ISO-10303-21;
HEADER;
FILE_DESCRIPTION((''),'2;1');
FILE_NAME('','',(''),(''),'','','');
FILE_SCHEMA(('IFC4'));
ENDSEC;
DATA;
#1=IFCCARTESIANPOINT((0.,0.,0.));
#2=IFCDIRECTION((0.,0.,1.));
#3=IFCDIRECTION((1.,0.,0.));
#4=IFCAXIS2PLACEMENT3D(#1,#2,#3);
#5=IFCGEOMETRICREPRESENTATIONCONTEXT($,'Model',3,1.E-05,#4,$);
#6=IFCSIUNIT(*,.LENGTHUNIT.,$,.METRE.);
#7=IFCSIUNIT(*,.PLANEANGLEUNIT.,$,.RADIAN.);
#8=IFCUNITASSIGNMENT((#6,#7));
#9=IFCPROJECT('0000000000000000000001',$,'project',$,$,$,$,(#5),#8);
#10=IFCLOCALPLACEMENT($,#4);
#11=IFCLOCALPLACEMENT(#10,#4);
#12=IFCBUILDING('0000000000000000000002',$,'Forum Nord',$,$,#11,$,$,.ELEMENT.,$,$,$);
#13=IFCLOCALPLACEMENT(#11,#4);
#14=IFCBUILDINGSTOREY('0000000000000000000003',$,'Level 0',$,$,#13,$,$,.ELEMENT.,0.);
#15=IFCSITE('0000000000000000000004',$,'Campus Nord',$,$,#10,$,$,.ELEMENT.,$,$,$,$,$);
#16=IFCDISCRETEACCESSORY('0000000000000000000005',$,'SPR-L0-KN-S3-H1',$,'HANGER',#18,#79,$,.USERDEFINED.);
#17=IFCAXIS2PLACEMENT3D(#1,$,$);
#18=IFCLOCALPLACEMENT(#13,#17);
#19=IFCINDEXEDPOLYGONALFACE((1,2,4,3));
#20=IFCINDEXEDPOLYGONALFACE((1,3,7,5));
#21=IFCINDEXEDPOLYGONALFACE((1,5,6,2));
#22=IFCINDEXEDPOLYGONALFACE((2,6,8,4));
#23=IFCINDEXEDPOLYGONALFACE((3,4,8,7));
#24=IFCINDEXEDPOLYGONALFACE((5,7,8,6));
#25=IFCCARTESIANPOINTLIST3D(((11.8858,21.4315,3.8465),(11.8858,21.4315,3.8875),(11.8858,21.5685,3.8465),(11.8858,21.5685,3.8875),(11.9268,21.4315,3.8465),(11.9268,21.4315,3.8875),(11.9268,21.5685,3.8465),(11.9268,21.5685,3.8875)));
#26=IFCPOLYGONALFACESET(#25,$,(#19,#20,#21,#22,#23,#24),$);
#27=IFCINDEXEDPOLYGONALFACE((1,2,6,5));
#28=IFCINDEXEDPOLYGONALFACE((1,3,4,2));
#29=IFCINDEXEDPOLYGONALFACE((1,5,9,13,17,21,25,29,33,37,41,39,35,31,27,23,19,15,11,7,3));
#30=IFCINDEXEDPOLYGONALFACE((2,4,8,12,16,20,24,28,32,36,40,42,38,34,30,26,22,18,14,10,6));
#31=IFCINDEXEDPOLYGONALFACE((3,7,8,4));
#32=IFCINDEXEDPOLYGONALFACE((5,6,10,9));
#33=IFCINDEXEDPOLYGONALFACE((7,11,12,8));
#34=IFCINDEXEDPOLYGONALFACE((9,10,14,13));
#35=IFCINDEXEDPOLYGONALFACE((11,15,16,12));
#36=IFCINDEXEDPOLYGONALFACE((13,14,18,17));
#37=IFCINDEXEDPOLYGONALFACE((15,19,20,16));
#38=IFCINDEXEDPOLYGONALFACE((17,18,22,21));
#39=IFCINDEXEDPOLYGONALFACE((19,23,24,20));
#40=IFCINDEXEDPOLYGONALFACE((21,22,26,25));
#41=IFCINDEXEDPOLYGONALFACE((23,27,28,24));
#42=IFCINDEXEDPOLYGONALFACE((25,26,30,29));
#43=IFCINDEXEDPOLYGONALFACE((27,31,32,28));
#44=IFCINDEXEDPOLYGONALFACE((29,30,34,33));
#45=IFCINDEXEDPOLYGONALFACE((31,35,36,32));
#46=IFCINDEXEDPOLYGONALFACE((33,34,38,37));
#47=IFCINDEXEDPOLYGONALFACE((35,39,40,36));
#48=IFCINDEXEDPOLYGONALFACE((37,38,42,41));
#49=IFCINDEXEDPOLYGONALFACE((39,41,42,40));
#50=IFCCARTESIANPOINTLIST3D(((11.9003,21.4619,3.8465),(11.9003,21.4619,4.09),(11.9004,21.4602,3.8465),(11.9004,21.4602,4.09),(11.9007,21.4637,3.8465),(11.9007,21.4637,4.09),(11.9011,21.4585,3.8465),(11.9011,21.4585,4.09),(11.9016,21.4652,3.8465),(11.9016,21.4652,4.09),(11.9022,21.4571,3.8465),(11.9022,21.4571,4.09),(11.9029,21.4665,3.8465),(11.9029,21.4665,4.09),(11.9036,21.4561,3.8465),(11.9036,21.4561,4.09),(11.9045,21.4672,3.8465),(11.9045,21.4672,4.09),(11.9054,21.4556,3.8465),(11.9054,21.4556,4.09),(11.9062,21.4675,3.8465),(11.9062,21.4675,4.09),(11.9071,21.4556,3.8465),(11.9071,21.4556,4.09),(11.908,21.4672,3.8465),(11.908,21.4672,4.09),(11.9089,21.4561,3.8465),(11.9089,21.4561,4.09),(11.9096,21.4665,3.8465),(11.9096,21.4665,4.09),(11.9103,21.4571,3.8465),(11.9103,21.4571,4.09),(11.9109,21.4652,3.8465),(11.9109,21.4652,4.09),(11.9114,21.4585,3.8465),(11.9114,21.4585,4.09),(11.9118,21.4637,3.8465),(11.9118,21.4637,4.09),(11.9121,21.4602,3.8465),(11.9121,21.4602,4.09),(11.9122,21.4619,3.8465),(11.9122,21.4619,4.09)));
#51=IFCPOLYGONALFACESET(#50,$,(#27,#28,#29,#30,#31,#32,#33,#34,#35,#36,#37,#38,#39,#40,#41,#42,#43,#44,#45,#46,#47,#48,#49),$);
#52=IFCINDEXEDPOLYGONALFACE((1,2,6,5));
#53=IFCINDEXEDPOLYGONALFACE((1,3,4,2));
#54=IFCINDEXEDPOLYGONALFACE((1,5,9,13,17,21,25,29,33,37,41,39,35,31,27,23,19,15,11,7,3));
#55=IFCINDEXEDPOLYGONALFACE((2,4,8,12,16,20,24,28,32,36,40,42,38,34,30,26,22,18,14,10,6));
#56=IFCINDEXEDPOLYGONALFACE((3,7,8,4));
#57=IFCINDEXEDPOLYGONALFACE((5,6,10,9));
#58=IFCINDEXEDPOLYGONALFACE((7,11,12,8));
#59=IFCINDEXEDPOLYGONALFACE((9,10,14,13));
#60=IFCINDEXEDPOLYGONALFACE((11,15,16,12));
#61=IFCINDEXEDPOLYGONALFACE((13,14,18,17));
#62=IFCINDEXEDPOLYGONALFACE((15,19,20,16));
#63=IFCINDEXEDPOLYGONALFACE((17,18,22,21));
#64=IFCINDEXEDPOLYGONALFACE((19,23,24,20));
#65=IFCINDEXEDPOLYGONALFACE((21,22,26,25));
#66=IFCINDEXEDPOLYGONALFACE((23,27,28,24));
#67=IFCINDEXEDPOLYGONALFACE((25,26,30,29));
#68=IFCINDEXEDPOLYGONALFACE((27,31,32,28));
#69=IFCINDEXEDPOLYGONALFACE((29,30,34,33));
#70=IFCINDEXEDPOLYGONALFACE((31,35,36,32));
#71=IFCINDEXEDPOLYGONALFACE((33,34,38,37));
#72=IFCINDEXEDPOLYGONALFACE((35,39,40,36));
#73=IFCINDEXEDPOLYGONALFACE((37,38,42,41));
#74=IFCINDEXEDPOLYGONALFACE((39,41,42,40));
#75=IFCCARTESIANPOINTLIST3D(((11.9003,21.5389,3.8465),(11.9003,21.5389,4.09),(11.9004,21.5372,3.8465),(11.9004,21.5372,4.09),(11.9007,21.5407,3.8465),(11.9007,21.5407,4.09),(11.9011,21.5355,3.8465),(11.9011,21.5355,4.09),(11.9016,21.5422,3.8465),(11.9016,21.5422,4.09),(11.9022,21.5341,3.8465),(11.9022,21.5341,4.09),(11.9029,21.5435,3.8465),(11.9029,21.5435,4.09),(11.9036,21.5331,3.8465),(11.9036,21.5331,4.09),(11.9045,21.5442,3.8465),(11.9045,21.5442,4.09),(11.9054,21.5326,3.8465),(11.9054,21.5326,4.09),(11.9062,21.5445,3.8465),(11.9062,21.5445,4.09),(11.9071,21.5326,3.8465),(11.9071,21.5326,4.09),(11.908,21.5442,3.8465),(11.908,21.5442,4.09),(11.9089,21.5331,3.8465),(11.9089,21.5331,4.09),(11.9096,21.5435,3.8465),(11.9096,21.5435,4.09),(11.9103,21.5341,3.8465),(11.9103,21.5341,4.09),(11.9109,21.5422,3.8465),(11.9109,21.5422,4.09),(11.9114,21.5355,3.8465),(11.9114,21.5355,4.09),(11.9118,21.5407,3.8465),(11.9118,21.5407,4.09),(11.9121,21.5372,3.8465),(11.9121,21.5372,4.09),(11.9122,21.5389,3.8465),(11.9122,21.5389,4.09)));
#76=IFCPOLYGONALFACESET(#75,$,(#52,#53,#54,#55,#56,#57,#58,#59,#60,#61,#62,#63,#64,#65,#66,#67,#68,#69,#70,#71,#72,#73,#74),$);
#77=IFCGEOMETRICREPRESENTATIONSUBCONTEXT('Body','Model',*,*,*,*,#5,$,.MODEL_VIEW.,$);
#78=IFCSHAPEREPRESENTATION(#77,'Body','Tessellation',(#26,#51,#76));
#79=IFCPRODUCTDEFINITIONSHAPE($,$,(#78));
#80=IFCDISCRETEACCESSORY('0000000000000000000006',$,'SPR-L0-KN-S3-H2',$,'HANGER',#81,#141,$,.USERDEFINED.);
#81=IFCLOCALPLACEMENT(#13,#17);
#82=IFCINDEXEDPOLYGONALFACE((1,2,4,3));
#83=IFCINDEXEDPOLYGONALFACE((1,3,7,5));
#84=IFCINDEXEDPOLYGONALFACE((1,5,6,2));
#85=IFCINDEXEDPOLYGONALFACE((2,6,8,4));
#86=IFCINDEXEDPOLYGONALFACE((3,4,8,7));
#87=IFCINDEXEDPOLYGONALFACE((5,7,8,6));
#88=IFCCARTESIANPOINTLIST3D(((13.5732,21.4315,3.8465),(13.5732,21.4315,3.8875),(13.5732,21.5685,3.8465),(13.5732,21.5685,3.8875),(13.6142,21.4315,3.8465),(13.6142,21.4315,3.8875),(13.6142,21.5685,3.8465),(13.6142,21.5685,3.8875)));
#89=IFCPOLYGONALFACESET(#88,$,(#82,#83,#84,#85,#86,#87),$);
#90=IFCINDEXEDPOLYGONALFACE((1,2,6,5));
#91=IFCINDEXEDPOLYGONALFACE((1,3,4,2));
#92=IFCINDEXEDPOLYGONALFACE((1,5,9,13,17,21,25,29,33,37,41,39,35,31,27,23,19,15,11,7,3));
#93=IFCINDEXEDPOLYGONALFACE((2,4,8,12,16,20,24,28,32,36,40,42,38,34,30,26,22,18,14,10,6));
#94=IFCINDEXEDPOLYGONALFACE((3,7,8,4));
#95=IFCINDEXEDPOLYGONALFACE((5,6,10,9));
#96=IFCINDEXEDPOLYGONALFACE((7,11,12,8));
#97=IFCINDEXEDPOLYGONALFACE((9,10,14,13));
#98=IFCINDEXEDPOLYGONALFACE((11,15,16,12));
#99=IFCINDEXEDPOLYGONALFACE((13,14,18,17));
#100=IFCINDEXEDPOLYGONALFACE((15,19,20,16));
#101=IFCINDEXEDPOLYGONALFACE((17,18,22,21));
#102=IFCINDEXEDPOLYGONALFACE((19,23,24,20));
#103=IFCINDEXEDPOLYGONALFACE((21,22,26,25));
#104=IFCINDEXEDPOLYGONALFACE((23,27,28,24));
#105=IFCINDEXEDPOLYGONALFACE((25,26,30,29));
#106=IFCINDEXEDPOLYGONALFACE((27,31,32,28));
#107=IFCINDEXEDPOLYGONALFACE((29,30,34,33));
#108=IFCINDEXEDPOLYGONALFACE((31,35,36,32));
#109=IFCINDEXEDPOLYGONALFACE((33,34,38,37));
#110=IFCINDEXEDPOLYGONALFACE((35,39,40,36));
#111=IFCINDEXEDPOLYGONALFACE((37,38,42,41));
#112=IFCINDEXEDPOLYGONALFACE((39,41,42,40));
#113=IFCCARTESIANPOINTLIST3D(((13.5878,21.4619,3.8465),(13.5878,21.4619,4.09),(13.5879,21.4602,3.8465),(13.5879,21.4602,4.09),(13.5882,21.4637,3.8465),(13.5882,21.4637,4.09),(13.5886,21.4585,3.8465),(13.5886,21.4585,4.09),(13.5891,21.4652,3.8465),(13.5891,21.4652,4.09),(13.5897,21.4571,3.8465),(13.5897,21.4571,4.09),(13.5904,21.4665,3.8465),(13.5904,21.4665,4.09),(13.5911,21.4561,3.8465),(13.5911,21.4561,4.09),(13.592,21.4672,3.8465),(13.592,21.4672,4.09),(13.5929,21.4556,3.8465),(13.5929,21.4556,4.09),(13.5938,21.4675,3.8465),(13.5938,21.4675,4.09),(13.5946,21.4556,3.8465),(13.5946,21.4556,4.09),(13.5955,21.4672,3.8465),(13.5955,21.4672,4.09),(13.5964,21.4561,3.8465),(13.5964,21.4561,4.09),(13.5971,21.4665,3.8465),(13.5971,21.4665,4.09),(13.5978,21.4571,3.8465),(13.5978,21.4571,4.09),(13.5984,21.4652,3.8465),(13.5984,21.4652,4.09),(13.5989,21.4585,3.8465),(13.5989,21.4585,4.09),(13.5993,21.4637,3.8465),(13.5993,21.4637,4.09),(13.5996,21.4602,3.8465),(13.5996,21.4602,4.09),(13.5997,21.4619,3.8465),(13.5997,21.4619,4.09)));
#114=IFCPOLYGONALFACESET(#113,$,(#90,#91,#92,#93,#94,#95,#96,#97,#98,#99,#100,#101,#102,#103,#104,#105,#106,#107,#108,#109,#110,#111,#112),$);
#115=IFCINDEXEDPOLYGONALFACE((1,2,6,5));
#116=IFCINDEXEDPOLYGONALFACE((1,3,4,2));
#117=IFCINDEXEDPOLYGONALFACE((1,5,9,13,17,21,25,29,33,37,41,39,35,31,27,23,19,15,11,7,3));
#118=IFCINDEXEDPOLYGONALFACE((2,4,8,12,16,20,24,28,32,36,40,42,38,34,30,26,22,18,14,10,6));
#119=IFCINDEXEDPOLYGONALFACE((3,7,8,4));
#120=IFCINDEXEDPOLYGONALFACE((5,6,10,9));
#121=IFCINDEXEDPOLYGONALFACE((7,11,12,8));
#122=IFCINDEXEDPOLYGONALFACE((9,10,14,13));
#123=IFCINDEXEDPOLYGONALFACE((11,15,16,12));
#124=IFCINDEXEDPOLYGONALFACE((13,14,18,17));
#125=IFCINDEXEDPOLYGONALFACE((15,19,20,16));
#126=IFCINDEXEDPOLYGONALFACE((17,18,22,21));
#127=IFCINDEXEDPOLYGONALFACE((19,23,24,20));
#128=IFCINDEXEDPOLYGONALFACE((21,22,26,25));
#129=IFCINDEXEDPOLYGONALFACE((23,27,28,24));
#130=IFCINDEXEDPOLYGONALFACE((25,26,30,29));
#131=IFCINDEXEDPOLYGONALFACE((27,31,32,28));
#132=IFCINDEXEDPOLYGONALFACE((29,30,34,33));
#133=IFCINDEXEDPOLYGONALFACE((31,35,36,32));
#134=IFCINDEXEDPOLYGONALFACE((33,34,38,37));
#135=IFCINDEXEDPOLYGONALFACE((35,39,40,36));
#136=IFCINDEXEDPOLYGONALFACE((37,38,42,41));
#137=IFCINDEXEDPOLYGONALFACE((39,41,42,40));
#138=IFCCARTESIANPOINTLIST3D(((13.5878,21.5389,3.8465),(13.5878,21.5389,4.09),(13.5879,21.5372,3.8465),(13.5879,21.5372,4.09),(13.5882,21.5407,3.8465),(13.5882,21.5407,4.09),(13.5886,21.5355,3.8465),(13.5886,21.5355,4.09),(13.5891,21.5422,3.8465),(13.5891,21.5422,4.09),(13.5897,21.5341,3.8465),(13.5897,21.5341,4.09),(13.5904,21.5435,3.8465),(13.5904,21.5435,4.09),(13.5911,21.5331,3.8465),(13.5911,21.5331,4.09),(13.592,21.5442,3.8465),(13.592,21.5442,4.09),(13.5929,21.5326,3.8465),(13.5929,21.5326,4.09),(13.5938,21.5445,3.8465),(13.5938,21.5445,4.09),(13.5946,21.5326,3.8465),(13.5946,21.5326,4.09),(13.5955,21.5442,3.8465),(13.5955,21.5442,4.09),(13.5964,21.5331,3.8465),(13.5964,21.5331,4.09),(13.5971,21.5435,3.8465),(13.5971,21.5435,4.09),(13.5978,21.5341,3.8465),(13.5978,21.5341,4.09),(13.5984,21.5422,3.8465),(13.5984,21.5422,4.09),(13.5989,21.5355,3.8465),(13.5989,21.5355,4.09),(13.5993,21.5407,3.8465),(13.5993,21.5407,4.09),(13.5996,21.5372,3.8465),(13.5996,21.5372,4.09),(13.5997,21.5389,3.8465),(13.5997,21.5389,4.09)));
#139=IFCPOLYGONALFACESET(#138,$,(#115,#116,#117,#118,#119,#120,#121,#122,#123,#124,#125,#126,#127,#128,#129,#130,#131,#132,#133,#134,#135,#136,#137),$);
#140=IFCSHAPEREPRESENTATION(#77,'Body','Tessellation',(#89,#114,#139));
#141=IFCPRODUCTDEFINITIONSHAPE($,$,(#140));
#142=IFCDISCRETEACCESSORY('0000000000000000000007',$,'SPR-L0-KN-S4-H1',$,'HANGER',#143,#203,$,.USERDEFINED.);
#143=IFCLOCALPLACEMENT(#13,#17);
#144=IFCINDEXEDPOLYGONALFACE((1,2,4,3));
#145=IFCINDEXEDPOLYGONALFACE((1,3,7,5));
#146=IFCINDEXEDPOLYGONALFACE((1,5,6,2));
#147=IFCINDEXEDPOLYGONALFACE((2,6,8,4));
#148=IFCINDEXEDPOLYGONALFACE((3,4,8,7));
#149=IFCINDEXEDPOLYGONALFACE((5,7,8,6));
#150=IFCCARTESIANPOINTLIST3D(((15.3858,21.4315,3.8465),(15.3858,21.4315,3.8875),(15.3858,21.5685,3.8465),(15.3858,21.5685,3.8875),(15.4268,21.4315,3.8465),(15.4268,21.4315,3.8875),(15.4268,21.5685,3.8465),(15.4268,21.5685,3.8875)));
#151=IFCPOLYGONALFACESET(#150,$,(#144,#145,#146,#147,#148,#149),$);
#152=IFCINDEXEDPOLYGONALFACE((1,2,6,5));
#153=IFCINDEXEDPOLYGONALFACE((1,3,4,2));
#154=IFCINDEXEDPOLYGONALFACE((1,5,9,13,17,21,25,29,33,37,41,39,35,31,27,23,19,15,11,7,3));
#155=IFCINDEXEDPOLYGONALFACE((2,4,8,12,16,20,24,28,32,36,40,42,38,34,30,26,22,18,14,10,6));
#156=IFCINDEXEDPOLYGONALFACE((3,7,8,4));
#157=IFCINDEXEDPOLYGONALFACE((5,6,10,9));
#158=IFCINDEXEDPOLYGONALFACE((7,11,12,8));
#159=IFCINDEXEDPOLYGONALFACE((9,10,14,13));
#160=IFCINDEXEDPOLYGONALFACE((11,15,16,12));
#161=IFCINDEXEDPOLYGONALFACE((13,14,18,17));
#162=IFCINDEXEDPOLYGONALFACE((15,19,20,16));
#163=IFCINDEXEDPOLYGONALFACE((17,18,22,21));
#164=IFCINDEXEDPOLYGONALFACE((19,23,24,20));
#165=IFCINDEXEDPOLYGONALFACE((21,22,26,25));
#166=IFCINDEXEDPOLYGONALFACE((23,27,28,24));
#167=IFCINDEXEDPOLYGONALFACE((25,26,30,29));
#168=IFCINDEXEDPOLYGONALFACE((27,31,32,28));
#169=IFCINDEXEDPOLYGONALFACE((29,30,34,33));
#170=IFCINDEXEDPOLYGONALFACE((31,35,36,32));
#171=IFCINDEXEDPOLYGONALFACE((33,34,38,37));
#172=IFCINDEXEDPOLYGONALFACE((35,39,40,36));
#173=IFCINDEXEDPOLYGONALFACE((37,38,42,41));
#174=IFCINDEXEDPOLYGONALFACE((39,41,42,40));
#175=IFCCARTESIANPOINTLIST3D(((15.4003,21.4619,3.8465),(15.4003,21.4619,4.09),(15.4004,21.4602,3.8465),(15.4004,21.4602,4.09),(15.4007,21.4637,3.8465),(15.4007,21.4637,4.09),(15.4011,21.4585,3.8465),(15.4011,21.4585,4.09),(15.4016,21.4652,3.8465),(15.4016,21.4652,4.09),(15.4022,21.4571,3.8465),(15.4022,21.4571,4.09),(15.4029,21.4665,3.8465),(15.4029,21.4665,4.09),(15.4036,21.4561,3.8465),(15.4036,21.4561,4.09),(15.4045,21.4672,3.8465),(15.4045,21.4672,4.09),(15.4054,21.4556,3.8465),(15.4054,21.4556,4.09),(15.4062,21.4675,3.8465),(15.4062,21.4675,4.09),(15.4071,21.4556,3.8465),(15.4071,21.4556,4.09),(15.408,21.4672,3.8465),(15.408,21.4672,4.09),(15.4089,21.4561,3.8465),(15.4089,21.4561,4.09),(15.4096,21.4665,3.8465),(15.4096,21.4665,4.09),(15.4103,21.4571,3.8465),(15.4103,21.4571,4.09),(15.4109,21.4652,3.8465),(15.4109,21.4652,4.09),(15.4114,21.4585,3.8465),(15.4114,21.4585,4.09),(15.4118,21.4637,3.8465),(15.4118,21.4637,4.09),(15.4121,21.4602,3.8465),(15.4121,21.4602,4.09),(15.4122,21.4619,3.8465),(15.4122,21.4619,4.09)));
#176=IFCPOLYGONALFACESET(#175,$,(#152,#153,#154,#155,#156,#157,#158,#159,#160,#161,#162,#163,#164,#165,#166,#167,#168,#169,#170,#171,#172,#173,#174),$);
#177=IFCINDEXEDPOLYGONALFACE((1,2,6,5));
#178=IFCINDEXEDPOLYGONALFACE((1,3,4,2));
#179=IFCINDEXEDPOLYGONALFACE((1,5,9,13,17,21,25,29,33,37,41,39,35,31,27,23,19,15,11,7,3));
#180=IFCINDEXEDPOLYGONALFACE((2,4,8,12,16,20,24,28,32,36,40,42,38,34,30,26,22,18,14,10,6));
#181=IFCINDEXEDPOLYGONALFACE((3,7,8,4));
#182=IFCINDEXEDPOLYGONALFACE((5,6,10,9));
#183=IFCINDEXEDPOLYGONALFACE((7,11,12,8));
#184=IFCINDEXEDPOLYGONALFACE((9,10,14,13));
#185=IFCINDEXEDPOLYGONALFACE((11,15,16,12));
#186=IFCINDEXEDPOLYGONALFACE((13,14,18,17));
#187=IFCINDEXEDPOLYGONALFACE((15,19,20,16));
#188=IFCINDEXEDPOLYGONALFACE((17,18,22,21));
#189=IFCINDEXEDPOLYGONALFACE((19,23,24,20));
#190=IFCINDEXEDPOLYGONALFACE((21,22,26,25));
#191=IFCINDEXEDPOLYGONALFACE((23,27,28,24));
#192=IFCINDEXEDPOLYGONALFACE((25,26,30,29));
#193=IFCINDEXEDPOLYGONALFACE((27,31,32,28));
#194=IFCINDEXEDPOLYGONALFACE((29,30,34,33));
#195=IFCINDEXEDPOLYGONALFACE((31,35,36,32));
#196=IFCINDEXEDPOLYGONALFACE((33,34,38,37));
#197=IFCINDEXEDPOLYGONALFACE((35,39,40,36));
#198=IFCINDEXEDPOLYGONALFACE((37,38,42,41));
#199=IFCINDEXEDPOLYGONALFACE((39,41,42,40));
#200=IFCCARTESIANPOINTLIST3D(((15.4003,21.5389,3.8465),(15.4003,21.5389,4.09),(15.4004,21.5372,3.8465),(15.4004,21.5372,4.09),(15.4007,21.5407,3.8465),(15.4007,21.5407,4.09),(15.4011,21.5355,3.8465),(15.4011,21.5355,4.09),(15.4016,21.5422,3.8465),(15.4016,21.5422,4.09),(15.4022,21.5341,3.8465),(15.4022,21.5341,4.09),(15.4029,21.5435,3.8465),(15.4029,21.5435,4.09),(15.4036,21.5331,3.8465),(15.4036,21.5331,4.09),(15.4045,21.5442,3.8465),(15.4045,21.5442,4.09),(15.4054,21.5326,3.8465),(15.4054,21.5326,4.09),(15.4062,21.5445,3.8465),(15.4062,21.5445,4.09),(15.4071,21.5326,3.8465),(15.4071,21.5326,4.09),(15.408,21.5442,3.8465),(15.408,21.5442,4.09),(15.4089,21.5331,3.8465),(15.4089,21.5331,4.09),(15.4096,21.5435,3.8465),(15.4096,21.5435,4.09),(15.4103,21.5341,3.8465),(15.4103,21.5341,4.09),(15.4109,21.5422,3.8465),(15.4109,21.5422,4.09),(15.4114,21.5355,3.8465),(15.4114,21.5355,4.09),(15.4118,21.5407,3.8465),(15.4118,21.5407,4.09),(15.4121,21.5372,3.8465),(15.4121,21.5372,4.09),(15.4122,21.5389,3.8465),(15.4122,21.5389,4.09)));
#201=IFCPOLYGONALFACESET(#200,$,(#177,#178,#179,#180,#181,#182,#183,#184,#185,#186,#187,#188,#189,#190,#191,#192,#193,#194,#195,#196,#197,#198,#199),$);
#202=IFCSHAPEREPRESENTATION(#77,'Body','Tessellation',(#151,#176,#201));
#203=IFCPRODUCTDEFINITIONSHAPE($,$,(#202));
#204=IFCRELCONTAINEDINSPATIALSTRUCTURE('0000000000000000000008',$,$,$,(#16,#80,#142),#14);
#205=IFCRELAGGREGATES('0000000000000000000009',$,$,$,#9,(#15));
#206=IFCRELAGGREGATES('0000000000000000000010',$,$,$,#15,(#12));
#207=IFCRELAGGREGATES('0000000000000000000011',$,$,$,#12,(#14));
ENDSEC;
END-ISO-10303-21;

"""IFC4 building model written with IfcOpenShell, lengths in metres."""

from ifc_helpers import new_model, si_unit, frame, frame_2d, origin_with_axes, origin_2d_with_axis, place, context, subcontext, project, spatial, rectangle, circle, extrude, element, save


model = new_model("IFC4")

# Units and contexts
model_context = context("Model", 3, precision=1e-05, world=origin_with_axes())
body_context = subcontext(model_context, "Body", "Model", "MODEL_VIEW")
ifc_project = project(units=[si_unit("LENGTHUNIT", "METRE"), si_unit("PLANEANGLEUNIT", "RADIAN")], contexts=[model_context])

# Site, building, storey
site_placement = place(None, origin_with_axes())
site = spatial("IfcSite", under=ifc_project, at=site_placement, Name="Campus Nord", CompositionType="ELEMENT")
building_placement = place(site_placement, origin_with_axes())
building = spatial("IfcBuilding", under=site, at=building_placement, Name="Forum Nord", CompositionType="ELEMENT")
storey_placement = place(building_placement, origin_with_axes())
storey = spatial("IfcBuildingStorey", under=building, at=storey_placement, Name="Level 0", CompositionType="ELEMENT", Elevation=0.0)

# Discrete accessories
for number, where, z_axis, x_axis, name in (
    (1, (11.9062, 21.5, 3.8875), (0.0, 0.0, 1.0), (0.0, 1.0, 0.0), "SPR-L0-KN-S3-H1"),
    (2, (13.5938, 21.5, 3.8875), (0.0, 0.0, 1.0), (0.0, 1.0, 0.0), "SPR-L0-KN-S3-H2"),
    (3, (15.4062, 21.5, 3.8875), (0.0, 0.0, 1.0), (0.0, 1.0, 0.0), "SPR-L0-KN-S4-H1"),
):
    element("IfcDiscreteAccessory", number, at=place(storey_placement, frame(where, z_axis=z_axis, x_axis=x_axis)), inside=storey, Name=name, ObjectType="HANGER", PredefinedType="USERDEFINED", context=body_context, shape_type="SweptSolid", body=[
        extrude(rectangle(XDim=0.137, YDim=0.041, at=origin_2d_with_axis()), frame((0.0, 0.0, -0.041), z_axis=(0.0, 0.0, 1.0), x_axis=(1.0, 0.0, 0.0)), (0.0, 0.0, 1.0), 0.041),
        extrude(circle(Radius=0.006, at=frame_2d((-0.0385, 0.0), x_axis=(1.0, 0.0))), frame((0.0, 0.0, -0.041), z_axis=(0.0, 0.0, 1.0), x_axis=(1.0, 0.0, 0.0)), (0.0, 0.0, 1.0), 0.2435),
        extrude(circle(Radius=0.006, at=frame_2d((0.0385, 0.0), x_axis=(1.0, 0.0))), frame((0.0, 0.0, -0.041), z_axis=(0.0, 0.0, 1.0), x_axis=(1.0, 0.0, 0.0)), (0.0, 0.0, 1.0), 0.2435),
    ])

save(model, "model.ifc")
